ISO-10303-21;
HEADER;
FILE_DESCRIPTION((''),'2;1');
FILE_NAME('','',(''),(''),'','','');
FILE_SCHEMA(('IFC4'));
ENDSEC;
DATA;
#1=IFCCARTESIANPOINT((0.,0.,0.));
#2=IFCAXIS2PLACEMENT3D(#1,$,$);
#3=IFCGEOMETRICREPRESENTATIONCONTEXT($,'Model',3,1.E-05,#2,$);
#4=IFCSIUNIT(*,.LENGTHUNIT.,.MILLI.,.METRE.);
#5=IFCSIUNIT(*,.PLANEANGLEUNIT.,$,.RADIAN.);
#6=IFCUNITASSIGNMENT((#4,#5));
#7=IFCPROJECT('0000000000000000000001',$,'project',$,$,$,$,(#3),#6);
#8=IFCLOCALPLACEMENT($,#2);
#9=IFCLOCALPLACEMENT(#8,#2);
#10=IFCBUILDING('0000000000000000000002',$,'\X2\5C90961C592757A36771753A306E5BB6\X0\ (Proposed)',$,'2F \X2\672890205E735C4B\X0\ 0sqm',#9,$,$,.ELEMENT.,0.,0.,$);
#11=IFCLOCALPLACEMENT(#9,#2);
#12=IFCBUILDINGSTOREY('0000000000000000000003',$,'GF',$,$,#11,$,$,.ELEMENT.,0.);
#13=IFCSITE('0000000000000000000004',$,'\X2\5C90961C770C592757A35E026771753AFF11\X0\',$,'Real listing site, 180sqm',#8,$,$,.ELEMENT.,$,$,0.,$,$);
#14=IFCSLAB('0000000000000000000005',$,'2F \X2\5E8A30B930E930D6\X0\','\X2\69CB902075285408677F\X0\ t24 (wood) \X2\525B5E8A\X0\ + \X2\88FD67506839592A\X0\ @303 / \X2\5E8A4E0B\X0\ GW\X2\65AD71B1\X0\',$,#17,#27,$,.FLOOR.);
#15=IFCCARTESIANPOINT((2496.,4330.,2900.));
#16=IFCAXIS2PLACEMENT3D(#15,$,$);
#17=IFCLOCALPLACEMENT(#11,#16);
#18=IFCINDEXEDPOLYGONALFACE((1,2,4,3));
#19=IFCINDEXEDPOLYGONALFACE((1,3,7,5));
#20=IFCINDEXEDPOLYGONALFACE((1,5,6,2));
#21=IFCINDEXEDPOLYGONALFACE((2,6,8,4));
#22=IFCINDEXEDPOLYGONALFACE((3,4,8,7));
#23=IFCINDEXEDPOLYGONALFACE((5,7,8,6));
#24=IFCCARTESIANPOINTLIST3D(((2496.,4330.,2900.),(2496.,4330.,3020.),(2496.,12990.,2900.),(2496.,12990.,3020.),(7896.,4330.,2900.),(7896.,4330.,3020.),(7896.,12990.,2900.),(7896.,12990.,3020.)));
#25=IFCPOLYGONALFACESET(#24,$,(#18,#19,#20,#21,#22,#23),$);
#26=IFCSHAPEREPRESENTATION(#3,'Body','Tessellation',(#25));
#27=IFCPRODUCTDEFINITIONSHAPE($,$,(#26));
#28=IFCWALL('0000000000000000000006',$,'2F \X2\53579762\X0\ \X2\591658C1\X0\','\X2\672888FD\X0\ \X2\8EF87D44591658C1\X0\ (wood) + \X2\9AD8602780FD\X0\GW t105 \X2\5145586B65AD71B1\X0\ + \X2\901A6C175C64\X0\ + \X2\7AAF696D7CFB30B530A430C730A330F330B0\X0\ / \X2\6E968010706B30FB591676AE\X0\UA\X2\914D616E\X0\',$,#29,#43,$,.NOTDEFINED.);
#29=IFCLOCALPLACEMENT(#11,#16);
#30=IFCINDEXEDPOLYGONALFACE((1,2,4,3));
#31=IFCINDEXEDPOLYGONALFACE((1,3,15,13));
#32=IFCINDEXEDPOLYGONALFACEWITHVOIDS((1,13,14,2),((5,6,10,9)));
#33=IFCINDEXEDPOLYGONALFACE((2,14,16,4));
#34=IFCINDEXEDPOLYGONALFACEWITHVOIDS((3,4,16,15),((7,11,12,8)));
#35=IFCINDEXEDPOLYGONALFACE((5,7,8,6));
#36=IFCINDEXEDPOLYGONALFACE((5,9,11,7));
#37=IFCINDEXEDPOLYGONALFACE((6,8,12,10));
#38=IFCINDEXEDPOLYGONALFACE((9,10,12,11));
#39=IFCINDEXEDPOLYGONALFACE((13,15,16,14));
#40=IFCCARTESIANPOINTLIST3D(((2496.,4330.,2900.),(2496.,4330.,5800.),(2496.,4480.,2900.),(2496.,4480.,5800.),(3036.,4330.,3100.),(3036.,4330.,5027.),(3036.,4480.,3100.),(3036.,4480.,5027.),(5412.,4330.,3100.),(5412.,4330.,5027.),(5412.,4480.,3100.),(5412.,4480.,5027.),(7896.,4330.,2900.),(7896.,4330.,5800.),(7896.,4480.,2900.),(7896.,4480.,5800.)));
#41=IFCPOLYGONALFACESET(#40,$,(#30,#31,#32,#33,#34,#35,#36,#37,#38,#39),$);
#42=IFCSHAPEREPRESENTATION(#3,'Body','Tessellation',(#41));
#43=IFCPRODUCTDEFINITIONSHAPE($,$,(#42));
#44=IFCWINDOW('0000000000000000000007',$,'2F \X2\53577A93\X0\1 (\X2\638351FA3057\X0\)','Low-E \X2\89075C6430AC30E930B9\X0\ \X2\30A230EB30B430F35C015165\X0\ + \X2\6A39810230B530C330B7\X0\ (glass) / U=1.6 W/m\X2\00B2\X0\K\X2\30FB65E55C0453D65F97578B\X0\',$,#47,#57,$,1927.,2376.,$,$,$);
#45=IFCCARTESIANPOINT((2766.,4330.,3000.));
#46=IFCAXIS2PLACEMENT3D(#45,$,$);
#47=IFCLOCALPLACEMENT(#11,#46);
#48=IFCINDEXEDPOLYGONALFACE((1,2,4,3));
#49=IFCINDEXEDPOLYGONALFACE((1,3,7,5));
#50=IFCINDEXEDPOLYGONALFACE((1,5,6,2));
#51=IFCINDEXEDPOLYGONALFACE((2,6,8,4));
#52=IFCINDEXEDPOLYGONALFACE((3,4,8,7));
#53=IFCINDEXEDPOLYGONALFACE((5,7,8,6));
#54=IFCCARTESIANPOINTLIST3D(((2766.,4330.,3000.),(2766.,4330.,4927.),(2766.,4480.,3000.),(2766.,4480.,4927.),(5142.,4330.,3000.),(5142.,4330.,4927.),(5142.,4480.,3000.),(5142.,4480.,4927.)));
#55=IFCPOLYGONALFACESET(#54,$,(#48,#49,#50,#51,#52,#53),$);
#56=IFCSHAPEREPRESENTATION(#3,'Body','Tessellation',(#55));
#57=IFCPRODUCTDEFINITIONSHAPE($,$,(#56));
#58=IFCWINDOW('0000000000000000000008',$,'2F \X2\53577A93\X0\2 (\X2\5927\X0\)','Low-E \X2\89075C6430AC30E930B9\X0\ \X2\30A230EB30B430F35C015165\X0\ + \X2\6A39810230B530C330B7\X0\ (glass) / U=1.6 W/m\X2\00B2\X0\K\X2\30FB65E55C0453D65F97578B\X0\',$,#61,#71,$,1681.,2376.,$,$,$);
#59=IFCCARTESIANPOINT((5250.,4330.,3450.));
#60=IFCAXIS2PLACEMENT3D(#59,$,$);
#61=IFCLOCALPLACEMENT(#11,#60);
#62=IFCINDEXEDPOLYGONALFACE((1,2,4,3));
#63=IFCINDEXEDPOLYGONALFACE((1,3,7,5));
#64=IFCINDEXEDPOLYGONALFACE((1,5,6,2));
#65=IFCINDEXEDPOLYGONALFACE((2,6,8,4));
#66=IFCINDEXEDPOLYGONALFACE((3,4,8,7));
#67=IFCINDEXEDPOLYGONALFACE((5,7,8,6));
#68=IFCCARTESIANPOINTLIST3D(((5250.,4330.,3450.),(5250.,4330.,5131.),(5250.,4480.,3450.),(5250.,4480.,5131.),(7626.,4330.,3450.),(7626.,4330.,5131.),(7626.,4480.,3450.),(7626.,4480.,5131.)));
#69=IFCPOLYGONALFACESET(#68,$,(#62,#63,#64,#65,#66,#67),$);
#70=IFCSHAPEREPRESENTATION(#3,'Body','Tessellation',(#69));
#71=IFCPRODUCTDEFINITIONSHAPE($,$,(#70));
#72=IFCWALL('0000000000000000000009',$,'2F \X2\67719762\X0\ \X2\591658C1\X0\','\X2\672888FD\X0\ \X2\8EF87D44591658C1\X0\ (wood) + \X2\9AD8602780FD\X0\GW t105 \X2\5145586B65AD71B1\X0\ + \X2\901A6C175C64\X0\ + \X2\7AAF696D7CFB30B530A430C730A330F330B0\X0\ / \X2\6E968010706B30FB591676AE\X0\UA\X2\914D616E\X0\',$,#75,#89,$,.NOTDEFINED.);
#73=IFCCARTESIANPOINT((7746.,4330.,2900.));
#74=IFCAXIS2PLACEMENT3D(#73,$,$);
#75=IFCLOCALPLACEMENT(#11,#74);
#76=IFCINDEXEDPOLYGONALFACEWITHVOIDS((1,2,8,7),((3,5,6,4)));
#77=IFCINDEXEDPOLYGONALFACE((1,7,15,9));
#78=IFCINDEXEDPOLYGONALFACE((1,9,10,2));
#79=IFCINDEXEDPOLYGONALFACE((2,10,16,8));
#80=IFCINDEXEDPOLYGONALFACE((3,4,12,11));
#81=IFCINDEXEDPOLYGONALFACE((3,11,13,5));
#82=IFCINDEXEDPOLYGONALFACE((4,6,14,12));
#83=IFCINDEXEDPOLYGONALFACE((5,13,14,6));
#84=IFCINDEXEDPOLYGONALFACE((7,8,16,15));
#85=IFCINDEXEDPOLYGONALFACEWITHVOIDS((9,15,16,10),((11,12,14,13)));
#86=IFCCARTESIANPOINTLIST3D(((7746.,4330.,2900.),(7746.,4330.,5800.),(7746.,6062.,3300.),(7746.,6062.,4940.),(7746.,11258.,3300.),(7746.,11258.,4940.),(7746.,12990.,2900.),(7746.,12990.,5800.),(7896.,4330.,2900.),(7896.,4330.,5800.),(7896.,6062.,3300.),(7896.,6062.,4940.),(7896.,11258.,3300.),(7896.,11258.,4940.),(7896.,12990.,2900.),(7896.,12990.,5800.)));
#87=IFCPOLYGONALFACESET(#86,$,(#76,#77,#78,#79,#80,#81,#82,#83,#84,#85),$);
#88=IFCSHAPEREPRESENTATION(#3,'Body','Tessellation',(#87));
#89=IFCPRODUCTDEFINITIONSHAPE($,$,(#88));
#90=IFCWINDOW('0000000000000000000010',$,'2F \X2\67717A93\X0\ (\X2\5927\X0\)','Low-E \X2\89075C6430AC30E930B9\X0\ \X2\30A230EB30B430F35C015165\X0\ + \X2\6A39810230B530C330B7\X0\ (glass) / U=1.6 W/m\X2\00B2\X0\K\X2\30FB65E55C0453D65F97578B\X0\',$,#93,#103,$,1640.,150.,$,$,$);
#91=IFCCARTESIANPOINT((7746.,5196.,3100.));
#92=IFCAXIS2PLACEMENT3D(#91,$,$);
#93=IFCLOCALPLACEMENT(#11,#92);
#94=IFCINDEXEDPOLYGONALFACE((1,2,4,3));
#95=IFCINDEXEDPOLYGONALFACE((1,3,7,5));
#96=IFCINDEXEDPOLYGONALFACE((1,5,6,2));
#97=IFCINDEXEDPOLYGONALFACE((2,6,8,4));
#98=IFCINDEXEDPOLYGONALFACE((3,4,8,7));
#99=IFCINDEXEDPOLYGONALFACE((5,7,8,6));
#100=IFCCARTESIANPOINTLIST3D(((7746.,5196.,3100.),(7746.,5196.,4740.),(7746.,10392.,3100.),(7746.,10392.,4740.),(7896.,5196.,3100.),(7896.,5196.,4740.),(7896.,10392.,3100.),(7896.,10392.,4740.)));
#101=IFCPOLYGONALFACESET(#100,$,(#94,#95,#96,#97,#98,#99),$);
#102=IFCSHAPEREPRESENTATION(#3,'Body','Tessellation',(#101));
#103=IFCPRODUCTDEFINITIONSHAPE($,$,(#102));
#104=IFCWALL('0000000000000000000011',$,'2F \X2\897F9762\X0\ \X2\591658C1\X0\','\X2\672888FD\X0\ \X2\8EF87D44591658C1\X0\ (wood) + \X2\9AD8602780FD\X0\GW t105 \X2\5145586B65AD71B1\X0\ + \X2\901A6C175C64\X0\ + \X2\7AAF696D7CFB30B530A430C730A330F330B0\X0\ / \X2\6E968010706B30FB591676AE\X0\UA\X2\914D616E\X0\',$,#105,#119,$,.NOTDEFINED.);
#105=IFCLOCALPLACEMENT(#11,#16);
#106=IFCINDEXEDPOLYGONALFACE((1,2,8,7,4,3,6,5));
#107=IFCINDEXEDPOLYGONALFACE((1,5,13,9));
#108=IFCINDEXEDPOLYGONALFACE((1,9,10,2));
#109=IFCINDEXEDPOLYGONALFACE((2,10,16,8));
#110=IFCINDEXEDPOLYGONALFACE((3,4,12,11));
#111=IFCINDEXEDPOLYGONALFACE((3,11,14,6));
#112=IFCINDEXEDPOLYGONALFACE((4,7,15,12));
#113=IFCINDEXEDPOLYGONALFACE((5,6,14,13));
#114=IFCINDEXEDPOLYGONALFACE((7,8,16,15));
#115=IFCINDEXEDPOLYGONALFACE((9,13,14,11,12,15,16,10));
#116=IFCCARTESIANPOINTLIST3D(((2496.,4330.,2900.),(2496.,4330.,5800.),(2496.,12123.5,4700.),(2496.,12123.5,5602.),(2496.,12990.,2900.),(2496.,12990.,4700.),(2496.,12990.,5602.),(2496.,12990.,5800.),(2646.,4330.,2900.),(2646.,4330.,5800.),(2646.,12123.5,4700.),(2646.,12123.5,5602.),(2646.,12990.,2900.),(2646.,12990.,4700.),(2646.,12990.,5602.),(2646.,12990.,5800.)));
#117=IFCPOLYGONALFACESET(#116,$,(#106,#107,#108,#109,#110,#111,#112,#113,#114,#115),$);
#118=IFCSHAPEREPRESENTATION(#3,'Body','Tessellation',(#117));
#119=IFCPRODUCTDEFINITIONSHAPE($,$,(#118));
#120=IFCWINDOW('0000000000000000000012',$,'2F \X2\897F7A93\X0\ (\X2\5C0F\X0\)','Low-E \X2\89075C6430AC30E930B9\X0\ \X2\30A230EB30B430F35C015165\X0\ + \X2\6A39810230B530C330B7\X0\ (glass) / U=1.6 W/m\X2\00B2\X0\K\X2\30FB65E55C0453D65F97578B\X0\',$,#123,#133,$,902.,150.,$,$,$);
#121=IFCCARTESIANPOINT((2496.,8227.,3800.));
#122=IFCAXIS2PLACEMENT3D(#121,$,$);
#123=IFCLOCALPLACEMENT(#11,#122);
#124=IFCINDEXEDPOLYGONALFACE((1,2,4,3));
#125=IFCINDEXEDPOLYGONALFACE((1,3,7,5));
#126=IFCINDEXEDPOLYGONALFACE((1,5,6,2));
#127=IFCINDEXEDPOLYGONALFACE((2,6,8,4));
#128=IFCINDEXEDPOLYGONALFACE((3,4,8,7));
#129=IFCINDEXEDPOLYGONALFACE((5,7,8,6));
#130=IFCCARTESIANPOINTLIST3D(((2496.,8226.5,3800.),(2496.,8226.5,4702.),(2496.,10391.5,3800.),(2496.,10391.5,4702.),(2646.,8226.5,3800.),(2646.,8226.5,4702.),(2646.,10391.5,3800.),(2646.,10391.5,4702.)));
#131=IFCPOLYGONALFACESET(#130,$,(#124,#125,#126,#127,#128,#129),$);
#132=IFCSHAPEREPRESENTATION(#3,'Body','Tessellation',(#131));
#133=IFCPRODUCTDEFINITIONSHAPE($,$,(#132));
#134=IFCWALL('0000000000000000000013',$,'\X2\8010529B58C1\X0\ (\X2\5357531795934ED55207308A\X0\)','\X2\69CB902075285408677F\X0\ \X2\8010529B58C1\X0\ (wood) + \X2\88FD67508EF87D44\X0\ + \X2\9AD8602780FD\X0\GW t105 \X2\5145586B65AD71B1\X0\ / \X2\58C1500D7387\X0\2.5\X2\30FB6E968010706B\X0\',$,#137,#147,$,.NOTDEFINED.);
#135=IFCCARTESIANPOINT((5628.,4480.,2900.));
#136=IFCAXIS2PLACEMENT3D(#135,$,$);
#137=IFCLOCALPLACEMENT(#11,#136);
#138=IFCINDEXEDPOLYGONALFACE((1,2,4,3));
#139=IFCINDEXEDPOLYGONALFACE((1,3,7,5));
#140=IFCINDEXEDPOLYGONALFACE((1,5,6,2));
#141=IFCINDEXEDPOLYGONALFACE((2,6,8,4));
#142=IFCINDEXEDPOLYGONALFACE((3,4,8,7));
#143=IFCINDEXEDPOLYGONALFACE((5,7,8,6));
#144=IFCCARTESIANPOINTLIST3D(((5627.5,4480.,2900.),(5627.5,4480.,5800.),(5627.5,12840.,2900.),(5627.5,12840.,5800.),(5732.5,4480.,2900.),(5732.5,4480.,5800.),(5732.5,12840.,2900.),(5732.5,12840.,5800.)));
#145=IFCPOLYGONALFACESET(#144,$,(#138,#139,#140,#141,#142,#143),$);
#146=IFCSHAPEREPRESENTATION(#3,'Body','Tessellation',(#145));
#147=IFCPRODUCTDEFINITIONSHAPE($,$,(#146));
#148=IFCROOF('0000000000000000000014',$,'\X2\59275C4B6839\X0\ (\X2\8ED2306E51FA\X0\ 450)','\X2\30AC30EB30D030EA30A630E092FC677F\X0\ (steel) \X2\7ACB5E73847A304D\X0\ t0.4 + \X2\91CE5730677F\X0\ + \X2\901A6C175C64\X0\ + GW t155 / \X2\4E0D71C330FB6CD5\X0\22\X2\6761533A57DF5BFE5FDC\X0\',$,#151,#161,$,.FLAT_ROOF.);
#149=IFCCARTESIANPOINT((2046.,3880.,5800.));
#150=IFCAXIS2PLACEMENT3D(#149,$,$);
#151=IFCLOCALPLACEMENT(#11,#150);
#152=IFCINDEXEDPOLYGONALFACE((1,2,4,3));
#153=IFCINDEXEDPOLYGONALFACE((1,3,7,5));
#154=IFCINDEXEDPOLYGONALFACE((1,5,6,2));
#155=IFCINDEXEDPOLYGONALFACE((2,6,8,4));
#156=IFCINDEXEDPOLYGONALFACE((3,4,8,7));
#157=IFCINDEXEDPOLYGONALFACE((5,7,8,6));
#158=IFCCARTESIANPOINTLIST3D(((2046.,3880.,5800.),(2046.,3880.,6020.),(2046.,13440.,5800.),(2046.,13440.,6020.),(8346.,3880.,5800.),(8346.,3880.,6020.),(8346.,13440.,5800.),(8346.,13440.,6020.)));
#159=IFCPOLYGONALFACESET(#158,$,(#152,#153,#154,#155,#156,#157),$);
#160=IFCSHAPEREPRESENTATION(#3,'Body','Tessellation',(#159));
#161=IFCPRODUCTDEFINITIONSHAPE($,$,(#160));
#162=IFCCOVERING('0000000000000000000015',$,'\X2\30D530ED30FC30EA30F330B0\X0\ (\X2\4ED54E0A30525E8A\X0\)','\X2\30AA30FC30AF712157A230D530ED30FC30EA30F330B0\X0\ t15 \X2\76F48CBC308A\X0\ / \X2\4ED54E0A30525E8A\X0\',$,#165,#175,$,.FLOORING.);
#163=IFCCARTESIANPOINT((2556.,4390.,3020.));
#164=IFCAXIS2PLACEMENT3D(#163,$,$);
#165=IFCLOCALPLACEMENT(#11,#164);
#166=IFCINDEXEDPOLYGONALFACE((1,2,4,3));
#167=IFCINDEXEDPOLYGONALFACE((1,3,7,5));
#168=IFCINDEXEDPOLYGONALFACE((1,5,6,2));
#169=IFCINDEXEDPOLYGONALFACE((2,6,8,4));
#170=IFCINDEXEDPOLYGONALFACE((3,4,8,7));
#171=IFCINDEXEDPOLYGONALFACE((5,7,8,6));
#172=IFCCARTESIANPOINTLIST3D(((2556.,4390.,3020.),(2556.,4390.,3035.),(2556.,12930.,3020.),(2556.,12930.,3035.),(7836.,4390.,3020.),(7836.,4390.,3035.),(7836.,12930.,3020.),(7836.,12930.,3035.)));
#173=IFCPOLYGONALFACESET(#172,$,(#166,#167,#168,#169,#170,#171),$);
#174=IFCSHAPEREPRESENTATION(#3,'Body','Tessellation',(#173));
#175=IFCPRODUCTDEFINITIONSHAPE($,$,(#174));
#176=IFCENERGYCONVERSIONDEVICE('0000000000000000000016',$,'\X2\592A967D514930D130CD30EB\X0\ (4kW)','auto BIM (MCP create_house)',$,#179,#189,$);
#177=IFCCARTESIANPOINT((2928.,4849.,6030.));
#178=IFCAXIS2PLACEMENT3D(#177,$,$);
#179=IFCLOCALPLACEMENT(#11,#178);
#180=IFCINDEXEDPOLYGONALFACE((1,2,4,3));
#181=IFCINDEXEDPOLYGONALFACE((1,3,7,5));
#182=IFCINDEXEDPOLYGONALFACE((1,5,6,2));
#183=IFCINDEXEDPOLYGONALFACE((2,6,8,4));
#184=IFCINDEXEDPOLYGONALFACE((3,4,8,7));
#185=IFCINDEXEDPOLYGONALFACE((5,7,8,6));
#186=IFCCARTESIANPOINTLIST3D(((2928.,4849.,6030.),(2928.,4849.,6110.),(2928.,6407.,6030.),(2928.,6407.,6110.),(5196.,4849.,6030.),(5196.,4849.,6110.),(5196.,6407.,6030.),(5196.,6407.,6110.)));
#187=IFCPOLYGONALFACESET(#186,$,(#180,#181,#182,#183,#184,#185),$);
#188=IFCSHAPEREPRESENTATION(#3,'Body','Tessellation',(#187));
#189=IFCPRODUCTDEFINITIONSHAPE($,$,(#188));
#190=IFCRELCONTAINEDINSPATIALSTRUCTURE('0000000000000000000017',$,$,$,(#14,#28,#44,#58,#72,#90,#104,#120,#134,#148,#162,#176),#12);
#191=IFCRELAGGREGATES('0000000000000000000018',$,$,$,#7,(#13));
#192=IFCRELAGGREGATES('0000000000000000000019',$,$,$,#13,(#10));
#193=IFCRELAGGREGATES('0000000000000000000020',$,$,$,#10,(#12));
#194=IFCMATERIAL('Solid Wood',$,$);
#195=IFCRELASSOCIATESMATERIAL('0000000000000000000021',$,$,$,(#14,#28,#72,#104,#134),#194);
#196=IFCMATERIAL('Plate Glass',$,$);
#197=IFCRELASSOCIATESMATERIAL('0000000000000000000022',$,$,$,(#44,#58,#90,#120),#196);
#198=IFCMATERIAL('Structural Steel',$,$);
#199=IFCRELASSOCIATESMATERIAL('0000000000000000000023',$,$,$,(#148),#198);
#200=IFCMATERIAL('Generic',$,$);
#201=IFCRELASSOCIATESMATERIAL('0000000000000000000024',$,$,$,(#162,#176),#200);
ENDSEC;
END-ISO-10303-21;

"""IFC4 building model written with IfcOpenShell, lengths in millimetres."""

from ifc_helpers import new_model, si_unit, frame, frame_2d, origin, place, context, project, spatial, rectangle, extrude, material, element, fill, save


model = new_model("IFC4")

# Units and contexts
model_context = context("Model", 3, precision=1e-05, world=origin())
ifc_project = project(units=[si_unit("LENGTHUNIT", "METRE", prefix="MILLI"), si_unit("PLANEANGLEUNIT", "RADIAN")], contexts=[model_context])

# Site, building, storey
site_placement = place(None, origin())
site = spatial("IfcSite", under=ifc_project, at=site_placement, Name="岐阜県大垣市東町１", ObjectType="Real listing site, 180sqm", CompositionType="ELEMENT", RefElevation=0.0)
building_placement = place(site_placement, origin())
building = spatial("IfcBuilding", under=site, at=building_placement, Name="岐阜大垣東町の家 (Proposed)", ObjectType="2F 木造平屋 0sqm", CompositionType="ELEMENT", ElevationOfRefHeight=0.0, ElevationOfTerrain=0.0)
storey_placement = place(building_placement, origin())
storey = spatial("IfcBuildingStorey", under=building, at=storey_placement, Name="GF", CompositionType="ELEMENT", Elevation=0.0)

# Slab
ifc_material_1 = material(Name="Solid Wood")
slab_placement = place(storey_placement, frame((2496.0, 4330.0, 2900.0)))
element("IfcSlab", 1, at=slab_placement, inside=storey, material=ifc_material_1, Name="2F 床スラブ", Description="構造用合板 t24 (wood) 剛床 + 製材根太 @303 / 床下 GW断熱", PredefinedType="FLOOR", context=model_context, shape_type="SweptSolid", body=[
    extrude(rectangle(XDim=5400.0, YDim=8660.0, at=frame_2d((2700.0, 4330.0))), frame((2496.0, 4330.0, 2900.0)), (0.0, 0.0, 1.0), 120.0),
])

# Wall, openings, windows
wall_1_placement = place(storey_placement, frame((2496.0, 4330.0, 2900.0)))
wall_1 = element("IfcWall", 2, at=wall_1_placement, inside=storey, material=ifc_material_1, Name="2F 南面 外壁", Description="木製 軸組外壁 (wood) + 高性能GW t105 充填断熱 + 通気層 + 窯業系サイディング / 準耐火・外皮UA配慮", PredefinedType="NOTDEFINED", context=model_context, shape_type="SweptSolid", body=[
    extrude(rectangle(XDim=5400.0, YDim=150.0, at=frame_2d((2700.0, 75.0))), frame((2496.0, 4330.0, 2900.0)), (0.0, 0.0, 1.0), 2900.0),
])
opening_1_placement = place(storey_placement, frame((2766.0, 4330.0, 3000.0)))
opening_1 = element("IfcOpeningElement", 3, at=opening_1_placement, cuts=wall_1, PredefinedType="NOTDEFINED", context=model_context, shape_type="SweptSolid", body=[
    extrude(rectangle(XDim=2376.0, YDim=150.0, at=frame_2d((1188.0, 75.0))), frame((2766.0, 4330.0, 3000.0)), (0.0, 0.0, 1.0), 1927.0),
])
opening_2_placement = place(storey_placement, frame((5250.0, 4330.0, 3450.0)))
opening_2 = element("IfcOpeningElement", 4, at=opening_2_placement, cuts=wall_1, PredefinedType="NOTDEFINED", context=model_context, shape_type="SweptSolid", body=[
    extrude(rectangle(XDim=2376.0, YDim=150.0, at=frame_2d((1188.0, 75.0))), frame((5250.0, 4330.0, 3450.0)), (0.0, 0.0, 1.0), 1681.0),
])
ifc_material_2 = material(Name="Plate Glass")
window_1_placement = place(storey_placement, frame((2766.0, 4330.0, 3000.0)))
window_1 = element("IfcWindow", 5, at=window_1_placement, inside=storey, material=ifc_material_2, Name="2F 南窓1 (掃出し)", Description="Low-E 複層ガラス アルゴン封入 + 樹脂サッシ (glass) / U=1.6 W/m²K・日射取得型", OverallHeight=1927.0, OverallWidth=2376.0, context=model_context, shape_type="SweptSolid", body=[
    extrude(rectangle(XDim=2376.0, YDim=150.0, at=frame_2d((1188.0, 75.0))), frame((2766.0, 4330.0, 3000.0)), (0.0, 0.0, 1.0), 1927.0),
])
fill(opening_1, window_1)
window_2_placement = place(storey_placement, frame((5250.0, 4330.0, 3450.0)))
window_2 = element("IfcWindow", 6, at=window_2_placement, inside=storey, material=ifc_material_2, Name="2F 南窓2 (大)", Description="Low-E 複層ガラス アルゴン封入 + 樹脂サッシ (glass) / U=1.6 W/m²K・日射取得型", OverallHeight=1681.0, OverallWidth=2376.0, context=model_context, shape_type="SweptSolid", body=[
    extrude(rectangle(XDim=2376.0, YDim=150.0, at=frame_2d((1188.0, 75.0))), frame((5250.0, 4330.0, 3450.0)), (0.0, 0.0, 1.0), 1681.0),
])
fill(opening_2, window_2)

# Walls, openings, windows
wall_2_placement = place(storey_placement, frame((7746.0, 4330.0, 2900.0)))
wall_2 = element("IfcWall", 7, at=wall_2_placement, inside=storey, material=ifc_material_1, Name="2F 東面 外壁", Description="木製 軸組外壁 (wood) + 高性能GW t105 充填断熱 + 通気層 + 窯業系サイディング / 準耐火・外皮UA配慮", PredefinedType="NOTDEFINED", context=model_context, shape_type="SweptSolid", body=[
    extrude(rectangle(XDim=150.0, YDim=8660.0, at=frame_2d((75.0, 4330.0))), frame((7746.0, 4330.0, 2900.0)), (0.0, 0.0, 1.0), 2900.0),
])
opening_3_placement = place(storey_placement, frame((7746.0, 5196.0, 3100.0)))
opening_3 = element("IfcOpeningElement", 8, at=opening_3_placement, cuts=wall_2, PredefinedType="NOTDEFINED", context=model_context, shape_type="SweptSolid", body=[
    extrude(rectangle(XDim=150.0, YDim=5196.0, at=frame_2d((75.0, 2598.0))), frame((7746.0, 5196.0, 3100.0)), (0.0, 0.0, 1.0), 1640.0),
])
window_3_placement = place(storey_placement, frame((7746.0, 5196.0, 3100.0)))
window_3 = element("IfcWindow", 9, at=window_3_placement, inside=storey, material=ifc_material_2, Name="2F 東窓 (大)", Description="Low-E 複層ガラス アルゴン封入 + 樹脂サッシ (glass) / U=1.6 W/m²K・日射取得型", OverallHeight=1640.0, OverallWidth=150.0, context=model_context, shape_type="SweptSolid", body=[
    extrude(rectangle(XDim=150.0, YDim=5196.0, at=frame_2d((75.0, 2598.0))), frame((7746.0, 5196.0, 3100.0)), (0.0, 0.0, 1.0), 1640.0),
])
fill(opening_3, window_3)
wall_3_placement = place(storey_placement, frame((2496.0, 4330.0, 2900.0)))
wall_3 = element("IfcWall", 10, at=wall_3_placement, inside=storey, material=ifc_material_1, Name="2F 西面 外壁", Description="木製 軸組外壁 (wood) + 高性能GW t105 充填断熱 + 通気層 + 窯業系サイディング / 準耐火・外皮UA配慮", PredefinedType="NOTDEFINED", context=model_context, shape_type="SweptSolid", body=[
    extrude(rectangle(XDim=150.0, YDim=8660.0, at=frame_2d((75.0, 4330.0))), frame((2496.0, 4330.0, 2900.0)), (0.0, 0.0, 1.0), 2900.0),
])
opening_4_placement = place(storey_placement, frame((2496.0, 8227.0, 3800.0)))
opening_4 = element("IfcOpeningElement", 11, at=opening_4_placement, cuts=wall_3, PredefinedType="NOTDEFINED", context=model_context, shape_type="SweptSolid", body=[
    extrude(rectangle(XDim=150.0, YDim=2165.0, at=frame_2d((75.0, 1082.0))), frame((2496.0, 8227.0, 3800.0)), (0.0, 0.0, 1.0), 902.0),
])
window_4_placement = place(storey_placement, frame((2496.0, 8227.0, 3800.0)))
window_4 = element("IfcWindow", 12, at=window_4_placement, inside=storey, material=ifc_material_2, Name="2F 西窓 (小)", Description="Low-E 複層ガラス アルゴン封入 + 樹脂サッシ (glass) / U=1.6 W/m²K・日射取得型", OverallHeight=902.0, OverallWidth=150.0, context=model_context, shape_type="SweptSolid", body=[
    extrude(rectangle(XDim=150.0, YDim=2165.0, at=frame_2d((75.0, 1082.0))), frame((2496.0, 8227.0, 3800.0)), (0.0, 0.0, 1.0), 902.0),
])
fill(opening_4, window_4)

# Wall
wall_4_placement = place(storey_placement, frame((5628.0, 4480.0, 2900.0)))
element("IfcWall", 13, at=wall_4_placement, inside=storey, material=ifc_material_1, Name="耐力壁 (南北間仕切り)", Description="構造用合板 耐力壁 (wood) + 製材軸組 + 高性能GW t105 充填断熱 / 壁倍率2.5・準耐火", PredefinedType="NOTDEFINED", context=model_context, shape_type="SweptSolid", body=[
    extrude(rectangle(XDim=105.0, YDim=8360.0, at=frame_2d((52.0, 4180.0))), frame((5628.0, 4480.0, 2900.0)), (0.0, 0.0, 1.0), 2900.0),
])

# Roof
ifc_material_3 = material(Name="Structural Steel")
roof_placement = place(storey_placement, frame((2046.0, 3880.0, 5800.0)))
element("IfcRoof", 14, at=roof_placement, inside=storey, material=ifc_material_3, Name="大屋根 (軒の出 450)", Description="ガルバリウム鋼板 (steel) 立平葺き t0.4 + 野地板 + 通気層 + GW t155 / 不燃・法22条区域対応", PredefinedType="FLAT_ROOF", context=model_context, shape_type="SweptSolid", body=[
    extrude(rectangle(XDim=6300.0, YDim=9560.0, at=frame_2d((3150.0, 4780.0))), frame((2046.0, 3880.0, 5800.0)), (0.0, 0.0, 1.0), 220.0),
])

# Covering
ifc_material_4 = material(Name="Generic")
covering_placement = place(storey_placement, frame((2556.0, 4390.0, 3020.0)))
element("IfcCovering", 15, at=covering_placement, inside=storey, material=ifc_material_4, Name="フローリング (仕上げ床)", Description="オーク無垢フローリング t15 直貼り / 仕上げ床", PredefinedType="FLOORING", context=model_context, shape_type="SweptSolid", body=[
    extrude(rectangle(XDim=5280.0, YDim=8540.0, at=frame_2d((2640.0, 4270.0))), frame((2556.0, 4390.0, 3020.0)), (0.0, 0.0, 1.0), 15.0),
])

# Energy conversion device
energy_conversion_device_placement = place(storey_placement, frame((2928.0, 4849.0, 6030.0)))
element("IfcEnergyConversionDevice", 16, at=energy_conversion_device_placement, inside=storey, material=ifc_material_4, Name="太陽光パネル (4kW)", Description="auto BIM (MCP create_house)", context=model_context, shape_type="SweptSolid", body=[
    extrude(rectangle(XDim=2268.0, YDim=1558.0, at=frame_2d((1134.0, 779.0))), frame((2928.0, 4849.0, 6030.0)), (0.0, 0.0, 1.0), 80.0),
])

save(model, "model.ifc")
